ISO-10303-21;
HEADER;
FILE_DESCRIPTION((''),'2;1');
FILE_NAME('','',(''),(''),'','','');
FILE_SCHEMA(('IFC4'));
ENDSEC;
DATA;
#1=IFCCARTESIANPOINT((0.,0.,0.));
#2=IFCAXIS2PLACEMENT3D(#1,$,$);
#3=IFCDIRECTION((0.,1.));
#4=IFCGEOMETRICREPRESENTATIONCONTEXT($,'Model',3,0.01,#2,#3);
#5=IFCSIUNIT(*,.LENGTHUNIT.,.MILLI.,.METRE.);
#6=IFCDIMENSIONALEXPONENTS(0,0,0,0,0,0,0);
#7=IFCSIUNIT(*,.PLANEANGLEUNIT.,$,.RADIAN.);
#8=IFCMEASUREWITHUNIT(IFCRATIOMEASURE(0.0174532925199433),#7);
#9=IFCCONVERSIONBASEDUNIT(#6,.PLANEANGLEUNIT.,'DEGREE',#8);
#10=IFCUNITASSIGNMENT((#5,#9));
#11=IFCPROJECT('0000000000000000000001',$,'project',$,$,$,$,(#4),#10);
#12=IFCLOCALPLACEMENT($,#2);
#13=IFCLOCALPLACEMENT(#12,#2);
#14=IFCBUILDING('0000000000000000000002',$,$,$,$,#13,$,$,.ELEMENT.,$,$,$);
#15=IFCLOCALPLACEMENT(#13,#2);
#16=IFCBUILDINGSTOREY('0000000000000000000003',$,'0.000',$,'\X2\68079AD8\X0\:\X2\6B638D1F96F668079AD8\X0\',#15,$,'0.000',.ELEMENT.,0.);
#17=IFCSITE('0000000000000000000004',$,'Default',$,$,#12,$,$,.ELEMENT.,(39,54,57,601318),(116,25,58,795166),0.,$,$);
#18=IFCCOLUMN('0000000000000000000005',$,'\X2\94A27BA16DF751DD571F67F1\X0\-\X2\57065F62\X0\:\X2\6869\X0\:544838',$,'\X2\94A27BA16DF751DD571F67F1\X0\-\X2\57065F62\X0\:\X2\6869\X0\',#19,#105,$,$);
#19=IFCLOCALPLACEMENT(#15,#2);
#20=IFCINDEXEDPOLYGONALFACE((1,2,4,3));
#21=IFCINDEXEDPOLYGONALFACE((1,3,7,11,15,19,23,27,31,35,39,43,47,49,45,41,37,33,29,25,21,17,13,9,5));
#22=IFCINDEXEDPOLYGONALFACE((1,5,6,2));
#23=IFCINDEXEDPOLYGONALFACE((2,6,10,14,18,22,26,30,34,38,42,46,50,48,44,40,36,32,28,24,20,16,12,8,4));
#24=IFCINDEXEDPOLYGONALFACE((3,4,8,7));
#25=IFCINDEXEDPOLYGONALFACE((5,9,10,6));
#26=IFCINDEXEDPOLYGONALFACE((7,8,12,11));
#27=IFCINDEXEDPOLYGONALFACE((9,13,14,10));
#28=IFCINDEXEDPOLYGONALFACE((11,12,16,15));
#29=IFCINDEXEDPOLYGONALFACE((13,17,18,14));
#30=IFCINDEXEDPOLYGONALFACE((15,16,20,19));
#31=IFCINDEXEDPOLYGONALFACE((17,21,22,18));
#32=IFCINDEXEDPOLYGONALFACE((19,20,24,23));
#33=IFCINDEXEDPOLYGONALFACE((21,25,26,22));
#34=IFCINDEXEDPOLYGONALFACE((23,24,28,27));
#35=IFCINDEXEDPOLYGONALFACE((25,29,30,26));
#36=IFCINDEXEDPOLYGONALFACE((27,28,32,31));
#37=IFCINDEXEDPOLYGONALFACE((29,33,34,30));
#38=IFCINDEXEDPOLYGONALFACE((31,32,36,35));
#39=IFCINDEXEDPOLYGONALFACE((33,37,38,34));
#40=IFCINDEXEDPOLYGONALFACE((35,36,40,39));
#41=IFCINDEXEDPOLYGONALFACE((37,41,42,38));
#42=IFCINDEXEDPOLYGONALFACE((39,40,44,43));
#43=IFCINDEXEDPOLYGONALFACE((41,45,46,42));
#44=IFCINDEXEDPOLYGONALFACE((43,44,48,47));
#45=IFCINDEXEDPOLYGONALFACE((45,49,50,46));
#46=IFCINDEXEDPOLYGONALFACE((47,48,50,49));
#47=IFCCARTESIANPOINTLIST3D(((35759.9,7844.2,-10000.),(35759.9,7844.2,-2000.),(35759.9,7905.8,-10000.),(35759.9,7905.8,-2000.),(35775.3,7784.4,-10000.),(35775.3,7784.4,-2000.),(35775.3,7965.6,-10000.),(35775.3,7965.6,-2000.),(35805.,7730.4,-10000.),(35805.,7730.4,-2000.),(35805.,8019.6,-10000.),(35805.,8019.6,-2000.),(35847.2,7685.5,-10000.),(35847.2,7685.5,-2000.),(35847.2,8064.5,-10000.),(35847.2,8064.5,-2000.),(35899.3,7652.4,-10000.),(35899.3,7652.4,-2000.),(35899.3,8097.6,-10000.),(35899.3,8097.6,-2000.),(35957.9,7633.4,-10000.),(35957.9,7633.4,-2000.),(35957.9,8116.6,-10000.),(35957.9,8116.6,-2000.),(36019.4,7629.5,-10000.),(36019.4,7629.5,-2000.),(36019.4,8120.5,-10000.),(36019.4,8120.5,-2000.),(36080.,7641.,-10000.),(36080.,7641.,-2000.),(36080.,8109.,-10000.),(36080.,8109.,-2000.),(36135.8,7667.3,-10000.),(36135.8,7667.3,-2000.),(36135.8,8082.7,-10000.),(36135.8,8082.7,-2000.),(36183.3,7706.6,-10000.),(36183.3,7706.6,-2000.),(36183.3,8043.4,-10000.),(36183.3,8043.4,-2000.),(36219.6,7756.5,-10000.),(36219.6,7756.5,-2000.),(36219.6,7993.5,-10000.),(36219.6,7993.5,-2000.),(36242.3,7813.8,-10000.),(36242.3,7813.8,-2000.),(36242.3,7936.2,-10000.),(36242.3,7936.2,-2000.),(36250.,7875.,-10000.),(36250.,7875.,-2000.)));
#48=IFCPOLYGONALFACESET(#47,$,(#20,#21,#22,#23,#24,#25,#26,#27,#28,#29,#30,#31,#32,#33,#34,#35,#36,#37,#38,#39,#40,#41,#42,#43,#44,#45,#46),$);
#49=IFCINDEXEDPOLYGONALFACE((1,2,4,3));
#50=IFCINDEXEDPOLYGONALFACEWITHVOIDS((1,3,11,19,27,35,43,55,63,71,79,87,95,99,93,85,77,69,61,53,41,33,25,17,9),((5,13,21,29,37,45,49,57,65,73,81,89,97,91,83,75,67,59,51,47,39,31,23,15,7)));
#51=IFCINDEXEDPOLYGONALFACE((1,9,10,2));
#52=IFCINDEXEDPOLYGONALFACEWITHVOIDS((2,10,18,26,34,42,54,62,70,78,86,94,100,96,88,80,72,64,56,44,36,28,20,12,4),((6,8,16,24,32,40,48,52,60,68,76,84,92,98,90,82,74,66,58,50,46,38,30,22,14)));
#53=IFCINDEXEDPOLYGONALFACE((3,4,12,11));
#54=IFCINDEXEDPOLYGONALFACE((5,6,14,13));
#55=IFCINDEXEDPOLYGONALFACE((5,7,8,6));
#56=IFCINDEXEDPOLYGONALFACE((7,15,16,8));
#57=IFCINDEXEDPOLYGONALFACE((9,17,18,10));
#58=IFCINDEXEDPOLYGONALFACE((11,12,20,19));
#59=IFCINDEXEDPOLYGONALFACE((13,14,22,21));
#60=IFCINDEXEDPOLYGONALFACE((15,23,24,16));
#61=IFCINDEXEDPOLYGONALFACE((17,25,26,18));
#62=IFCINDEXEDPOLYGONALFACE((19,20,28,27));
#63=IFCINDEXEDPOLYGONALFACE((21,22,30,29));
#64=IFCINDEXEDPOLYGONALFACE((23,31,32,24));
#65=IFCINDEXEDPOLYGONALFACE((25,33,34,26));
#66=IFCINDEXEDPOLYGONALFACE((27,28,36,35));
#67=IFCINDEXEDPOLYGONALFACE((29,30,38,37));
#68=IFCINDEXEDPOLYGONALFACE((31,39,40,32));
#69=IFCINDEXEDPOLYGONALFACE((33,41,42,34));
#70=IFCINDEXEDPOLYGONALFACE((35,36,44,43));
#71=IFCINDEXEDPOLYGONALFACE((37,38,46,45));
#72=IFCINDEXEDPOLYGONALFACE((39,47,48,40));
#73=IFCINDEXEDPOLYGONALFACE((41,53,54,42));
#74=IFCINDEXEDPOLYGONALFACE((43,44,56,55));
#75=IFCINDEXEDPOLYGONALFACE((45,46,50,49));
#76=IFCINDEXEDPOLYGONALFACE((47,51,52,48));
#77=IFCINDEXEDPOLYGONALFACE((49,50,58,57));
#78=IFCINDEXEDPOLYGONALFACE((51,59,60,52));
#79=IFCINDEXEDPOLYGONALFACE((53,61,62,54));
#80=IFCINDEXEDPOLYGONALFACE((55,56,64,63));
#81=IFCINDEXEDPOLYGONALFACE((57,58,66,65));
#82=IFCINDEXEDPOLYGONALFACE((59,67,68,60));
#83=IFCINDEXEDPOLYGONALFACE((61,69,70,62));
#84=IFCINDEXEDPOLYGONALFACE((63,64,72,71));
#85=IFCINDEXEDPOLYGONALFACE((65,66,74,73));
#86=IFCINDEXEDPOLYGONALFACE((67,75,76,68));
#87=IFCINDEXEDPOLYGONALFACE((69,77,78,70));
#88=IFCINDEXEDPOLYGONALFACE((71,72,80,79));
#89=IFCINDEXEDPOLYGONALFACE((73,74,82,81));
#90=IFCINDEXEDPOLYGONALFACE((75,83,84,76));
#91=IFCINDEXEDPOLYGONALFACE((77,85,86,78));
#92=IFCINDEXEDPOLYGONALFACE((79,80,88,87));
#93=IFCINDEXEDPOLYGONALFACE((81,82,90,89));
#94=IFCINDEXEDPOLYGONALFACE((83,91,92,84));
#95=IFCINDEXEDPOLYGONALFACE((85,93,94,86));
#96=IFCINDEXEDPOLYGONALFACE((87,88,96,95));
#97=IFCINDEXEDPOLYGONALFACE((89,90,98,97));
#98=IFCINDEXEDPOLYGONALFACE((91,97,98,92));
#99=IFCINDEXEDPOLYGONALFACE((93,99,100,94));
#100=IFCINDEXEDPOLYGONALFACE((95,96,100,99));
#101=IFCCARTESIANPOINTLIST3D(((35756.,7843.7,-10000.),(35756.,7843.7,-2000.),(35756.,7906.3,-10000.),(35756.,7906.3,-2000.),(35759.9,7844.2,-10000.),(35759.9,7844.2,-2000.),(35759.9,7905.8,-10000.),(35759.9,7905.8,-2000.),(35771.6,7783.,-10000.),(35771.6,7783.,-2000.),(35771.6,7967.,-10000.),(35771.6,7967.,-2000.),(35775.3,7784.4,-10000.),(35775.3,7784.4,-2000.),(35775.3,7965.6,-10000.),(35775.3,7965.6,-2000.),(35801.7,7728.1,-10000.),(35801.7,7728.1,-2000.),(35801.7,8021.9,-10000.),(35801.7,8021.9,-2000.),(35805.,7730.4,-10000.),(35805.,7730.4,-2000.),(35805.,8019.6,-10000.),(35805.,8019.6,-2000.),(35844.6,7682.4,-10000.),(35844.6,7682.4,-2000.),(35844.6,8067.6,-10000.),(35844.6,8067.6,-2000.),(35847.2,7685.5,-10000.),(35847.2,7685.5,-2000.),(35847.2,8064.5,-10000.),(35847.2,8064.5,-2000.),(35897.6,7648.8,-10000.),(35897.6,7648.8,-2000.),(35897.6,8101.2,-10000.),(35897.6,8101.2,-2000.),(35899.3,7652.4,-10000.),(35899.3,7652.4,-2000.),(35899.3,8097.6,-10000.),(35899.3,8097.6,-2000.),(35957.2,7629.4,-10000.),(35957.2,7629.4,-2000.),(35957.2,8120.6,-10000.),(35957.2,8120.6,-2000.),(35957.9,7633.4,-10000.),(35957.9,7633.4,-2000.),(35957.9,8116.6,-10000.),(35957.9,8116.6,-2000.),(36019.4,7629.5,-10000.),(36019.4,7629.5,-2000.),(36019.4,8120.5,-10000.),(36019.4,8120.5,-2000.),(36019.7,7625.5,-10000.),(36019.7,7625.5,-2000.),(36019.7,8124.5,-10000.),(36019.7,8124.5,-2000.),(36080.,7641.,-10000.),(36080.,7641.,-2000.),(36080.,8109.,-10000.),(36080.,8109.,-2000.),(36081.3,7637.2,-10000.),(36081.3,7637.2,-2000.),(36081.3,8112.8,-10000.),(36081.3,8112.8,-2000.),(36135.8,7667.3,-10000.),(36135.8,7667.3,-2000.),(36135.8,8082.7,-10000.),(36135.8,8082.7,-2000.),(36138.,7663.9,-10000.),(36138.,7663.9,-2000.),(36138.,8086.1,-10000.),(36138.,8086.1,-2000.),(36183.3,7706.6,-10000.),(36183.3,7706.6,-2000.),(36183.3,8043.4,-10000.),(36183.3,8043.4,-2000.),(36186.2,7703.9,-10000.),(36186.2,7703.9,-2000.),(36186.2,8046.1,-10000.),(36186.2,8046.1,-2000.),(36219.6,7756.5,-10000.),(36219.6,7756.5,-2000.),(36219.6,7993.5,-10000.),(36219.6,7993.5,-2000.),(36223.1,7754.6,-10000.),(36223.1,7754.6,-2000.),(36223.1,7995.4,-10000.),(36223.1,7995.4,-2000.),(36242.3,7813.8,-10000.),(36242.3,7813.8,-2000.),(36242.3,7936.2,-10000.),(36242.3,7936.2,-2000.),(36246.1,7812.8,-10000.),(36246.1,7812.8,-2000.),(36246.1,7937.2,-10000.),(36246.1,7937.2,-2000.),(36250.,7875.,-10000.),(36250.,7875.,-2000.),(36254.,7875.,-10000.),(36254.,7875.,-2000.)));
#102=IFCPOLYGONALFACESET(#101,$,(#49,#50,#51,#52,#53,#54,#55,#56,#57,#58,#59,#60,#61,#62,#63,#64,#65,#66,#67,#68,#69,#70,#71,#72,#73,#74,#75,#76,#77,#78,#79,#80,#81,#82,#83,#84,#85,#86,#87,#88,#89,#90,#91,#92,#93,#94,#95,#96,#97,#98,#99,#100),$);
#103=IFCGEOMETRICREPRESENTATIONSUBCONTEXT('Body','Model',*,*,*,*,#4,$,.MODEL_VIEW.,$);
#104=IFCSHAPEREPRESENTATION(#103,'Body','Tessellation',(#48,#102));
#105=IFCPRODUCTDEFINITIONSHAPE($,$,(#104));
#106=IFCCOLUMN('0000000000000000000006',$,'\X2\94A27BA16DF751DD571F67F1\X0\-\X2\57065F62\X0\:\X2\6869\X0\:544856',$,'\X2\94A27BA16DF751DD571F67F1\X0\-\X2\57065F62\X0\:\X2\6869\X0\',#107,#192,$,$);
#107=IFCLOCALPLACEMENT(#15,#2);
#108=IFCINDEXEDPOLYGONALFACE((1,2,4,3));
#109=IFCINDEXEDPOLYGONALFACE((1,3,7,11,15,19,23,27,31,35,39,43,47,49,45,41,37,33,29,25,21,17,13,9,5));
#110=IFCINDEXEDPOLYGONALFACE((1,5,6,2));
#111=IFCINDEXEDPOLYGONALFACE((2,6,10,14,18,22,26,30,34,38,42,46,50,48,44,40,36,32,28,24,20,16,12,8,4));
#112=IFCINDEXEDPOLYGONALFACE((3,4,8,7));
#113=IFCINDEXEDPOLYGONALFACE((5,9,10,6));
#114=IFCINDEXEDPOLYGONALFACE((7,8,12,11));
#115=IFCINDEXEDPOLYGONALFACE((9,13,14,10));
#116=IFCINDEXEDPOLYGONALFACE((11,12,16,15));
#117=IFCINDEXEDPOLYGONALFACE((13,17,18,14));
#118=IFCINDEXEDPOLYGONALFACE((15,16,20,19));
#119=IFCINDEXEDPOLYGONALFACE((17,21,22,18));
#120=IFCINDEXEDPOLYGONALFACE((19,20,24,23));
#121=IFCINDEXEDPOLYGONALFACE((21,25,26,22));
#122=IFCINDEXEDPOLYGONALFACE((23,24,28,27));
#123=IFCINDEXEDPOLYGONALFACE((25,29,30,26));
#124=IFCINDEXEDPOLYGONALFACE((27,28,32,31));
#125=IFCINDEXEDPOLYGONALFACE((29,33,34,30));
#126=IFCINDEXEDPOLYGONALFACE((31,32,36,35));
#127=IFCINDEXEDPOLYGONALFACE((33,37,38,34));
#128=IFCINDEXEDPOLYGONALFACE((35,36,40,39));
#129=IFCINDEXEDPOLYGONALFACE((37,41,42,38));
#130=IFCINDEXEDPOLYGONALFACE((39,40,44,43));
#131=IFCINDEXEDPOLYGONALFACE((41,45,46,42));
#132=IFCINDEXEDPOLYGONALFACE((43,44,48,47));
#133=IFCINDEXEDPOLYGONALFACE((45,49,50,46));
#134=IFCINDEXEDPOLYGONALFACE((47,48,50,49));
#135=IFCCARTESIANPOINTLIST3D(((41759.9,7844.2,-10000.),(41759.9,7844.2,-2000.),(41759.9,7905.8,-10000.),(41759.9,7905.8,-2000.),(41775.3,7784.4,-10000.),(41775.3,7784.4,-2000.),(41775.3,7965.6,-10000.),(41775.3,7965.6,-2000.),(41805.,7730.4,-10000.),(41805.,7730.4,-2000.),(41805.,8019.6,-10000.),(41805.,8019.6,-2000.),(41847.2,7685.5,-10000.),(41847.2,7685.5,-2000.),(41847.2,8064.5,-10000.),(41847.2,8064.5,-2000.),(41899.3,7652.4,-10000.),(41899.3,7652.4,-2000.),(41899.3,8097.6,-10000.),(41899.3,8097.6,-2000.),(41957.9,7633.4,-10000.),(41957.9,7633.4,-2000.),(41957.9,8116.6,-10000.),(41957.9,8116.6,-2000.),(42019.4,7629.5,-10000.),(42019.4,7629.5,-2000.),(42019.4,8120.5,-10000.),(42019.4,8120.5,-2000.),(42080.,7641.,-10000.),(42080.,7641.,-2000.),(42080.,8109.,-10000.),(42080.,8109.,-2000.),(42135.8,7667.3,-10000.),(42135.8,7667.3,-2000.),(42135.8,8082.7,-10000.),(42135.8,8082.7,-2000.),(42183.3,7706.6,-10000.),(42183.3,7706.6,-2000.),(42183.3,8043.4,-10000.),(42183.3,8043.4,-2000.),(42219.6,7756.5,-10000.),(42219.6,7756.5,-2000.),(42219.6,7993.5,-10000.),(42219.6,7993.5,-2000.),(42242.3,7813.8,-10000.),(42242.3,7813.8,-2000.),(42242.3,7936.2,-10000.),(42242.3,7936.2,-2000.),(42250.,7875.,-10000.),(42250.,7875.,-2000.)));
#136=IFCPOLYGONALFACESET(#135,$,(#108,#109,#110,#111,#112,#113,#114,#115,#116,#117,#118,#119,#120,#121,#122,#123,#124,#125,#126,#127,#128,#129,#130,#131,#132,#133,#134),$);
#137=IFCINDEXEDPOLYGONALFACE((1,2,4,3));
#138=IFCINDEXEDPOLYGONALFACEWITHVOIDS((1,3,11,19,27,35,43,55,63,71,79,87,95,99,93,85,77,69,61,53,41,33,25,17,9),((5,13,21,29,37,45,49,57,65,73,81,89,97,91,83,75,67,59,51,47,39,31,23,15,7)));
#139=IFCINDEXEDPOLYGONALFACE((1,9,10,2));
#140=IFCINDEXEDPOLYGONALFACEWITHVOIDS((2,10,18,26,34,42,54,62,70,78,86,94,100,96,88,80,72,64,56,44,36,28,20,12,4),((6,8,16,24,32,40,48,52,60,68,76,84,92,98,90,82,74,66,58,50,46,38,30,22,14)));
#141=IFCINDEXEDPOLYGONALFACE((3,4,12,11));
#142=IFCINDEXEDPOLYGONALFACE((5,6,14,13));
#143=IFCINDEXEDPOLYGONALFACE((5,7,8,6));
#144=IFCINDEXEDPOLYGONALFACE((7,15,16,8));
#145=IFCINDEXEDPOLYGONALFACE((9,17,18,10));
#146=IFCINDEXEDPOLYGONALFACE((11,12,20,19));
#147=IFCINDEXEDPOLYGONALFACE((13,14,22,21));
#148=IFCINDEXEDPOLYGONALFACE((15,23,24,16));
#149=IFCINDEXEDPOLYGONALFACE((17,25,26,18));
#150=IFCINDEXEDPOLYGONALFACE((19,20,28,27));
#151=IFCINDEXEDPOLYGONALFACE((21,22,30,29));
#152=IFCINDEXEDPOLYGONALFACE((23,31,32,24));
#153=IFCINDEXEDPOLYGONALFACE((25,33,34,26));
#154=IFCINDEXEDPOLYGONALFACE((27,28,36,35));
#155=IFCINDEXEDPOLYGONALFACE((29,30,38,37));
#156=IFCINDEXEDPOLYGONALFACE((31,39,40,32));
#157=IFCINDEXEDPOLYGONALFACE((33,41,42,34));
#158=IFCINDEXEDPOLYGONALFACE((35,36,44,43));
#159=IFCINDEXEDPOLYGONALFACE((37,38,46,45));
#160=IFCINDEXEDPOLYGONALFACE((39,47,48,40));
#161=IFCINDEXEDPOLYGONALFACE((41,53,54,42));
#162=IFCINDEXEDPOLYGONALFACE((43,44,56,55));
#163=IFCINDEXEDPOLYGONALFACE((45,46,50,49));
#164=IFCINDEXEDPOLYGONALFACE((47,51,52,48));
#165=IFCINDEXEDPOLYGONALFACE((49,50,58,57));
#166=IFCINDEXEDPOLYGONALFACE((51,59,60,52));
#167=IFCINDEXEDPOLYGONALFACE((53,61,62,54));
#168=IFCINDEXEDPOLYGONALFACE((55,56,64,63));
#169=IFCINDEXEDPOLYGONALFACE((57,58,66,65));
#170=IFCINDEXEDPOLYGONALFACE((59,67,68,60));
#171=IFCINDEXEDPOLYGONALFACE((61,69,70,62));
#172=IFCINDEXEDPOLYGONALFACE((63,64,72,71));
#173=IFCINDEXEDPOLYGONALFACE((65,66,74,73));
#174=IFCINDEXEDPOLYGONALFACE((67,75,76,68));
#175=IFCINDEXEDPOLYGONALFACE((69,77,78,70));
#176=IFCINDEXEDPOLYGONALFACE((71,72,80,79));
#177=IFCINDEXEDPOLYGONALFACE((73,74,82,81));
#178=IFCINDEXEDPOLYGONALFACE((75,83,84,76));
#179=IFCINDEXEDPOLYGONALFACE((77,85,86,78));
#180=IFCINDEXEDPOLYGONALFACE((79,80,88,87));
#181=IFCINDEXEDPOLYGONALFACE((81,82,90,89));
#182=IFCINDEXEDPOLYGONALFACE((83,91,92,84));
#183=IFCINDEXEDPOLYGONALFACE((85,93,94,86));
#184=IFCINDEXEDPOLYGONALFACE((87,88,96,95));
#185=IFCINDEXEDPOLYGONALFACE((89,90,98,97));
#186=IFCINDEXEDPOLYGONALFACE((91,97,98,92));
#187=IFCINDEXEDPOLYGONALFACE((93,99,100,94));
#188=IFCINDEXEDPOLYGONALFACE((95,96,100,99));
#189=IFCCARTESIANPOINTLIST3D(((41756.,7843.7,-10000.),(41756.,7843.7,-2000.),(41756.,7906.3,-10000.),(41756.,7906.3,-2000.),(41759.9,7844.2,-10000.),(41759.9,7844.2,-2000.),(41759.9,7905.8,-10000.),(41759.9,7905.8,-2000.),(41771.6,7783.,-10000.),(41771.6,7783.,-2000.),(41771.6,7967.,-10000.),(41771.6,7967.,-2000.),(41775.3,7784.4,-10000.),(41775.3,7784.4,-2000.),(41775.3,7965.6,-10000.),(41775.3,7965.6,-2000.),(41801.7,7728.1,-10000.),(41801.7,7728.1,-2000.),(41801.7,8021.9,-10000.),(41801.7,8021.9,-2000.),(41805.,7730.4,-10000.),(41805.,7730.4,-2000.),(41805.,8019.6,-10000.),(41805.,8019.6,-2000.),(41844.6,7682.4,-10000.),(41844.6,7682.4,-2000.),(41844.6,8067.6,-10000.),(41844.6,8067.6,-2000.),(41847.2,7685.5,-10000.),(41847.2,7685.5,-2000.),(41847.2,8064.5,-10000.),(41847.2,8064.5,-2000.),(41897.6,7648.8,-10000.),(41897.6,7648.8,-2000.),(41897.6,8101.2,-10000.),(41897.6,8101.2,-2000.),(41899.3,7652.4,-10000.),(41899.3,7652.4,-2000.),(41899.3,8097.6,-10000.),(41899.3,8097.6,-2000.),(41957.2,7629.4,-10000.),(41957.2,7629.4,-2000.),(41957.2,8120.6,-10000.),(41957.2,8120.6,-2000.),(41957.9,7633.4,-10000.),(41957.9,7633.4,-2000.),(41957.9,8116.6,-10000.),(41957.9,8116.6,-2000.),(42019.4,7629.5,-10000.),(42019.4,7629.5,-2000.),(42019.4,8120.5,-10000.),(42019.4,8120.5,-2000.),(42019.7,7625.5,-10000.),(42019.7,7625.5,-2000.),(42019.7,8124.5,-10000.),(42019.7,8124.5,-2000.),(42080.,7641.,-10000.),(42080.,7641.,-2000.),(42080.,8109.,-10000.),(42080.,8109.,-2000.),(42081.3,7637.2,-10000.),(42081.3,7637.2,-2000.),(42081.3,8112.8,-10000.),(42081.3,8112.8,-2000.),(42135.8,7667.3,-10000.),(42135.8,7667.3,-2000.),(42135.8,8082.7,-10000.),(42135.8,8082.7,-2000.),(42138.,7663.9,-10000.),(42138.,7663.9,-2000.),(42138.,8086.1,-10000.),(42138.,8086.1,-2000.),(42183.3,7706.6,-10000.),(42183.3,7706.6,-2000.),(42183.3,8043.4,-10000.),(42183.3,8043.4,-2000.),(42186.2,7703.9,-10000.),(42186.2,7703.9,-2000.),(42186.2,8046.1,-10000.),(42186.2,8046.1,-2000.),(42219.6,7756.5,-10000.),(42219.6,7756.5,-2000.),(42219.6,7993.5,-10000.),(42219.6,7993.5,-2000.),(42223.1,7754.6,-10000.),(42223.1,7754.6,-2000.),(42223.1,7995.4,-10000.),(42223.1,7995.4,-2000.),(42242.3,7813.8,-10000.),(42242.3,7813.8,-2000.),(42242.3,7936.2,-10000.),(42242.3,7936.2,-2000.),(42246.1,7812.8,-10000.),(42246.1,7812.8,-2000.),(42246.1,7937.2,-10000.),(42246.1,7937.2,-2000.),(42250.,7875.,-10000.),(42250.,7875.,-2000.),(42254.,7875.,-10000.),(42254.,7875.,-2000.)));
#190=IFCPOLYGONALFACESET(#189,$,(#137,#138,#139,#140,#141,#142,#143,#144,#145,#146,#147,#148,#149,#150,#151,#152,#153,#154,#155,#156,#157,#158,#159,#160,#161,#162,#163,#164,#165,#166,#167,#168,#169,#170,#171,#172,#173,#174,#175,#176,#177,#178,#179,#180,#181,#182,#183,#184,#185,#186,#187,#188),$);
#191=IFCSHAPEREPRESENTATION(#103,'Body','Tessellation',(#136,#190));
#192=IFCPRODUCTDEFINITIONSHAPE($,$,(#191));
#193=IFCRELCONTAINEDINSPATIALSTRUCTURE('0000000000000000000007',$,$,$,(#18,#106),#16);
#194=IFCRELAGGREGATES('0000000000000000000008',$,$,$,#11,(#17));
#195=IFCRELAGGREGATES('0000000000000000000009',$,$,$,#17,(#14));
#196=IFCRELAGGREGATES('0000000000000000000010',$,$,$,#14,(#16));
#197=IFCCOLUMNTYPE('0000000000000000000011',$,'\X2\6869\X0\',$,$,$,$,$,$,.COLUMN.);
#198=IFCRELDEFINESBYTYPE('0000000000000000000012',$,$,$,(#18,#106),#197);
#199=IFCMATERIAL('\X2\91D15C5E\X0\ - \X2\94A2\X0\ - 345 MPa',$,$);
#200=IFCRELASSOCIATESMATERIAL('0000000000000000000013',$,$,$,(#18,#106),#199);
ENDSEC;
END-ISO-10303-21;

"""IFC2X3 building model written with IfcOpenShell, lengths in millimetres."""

from ifc_helpers import new_model, entity, si_unit, converted_unit, direction, frame, frame_2d, origin, place, context, subcontext, project, spatial, circle, hollow_circle, extrude, source, transform, mapped, material, type_object, type_shapes, element, save


model = new_model("IFC2X3")

# Units and contexts
model_context = context("Model", 3, precision=0.01, world=origin(), true_north=direction((0.0, 1.0)))
body_context = subcontext(model_context, "Body", "Model", "MODEL_VIEW")
ifc_project = project(units=[si_unit("LENGTHUNIT", "METRE", prefix="MILLI"), converted_unit("PLANEANGLEUNIT", "DEGREE", entity("IfcRatioMeasure", 0.0174532925199433), si_unit("PLANEANGLEUNIT", "RADIAN"), dimensions=[0, 0, 0, 0, 0, 0, 0])], contexts=[model_context])

# Site, building, storey
site_placement = place(None, origin())
site = spatial("IfcSite", under=ifc_project, at=site_placement, Name="Default", CompositionType="ELEMENT", RefLatitude=(39, 54, 57, 601318), RefLongitude=(116, 25, 58, 795166), RefElevation=0.0)
building_placement = place(site_placement, origin())
building = spatial("IfcBuilding", under=site, at=building_placement, CompositionType="ELEMENT")
storey_placement = place(building_placement, origin())
storey = spatial("IfcBuildingStorey", under=building, at=storey_placement, Name="0.000", ObjectType="标高:正负零标高", LongName="0.000", CompositionType="ELEMENT", Elevation=0.0)

# Columns
ifc_material_1 = material(Name="金属 - 钢 - 345 MPa")
column_type = type_object("IfcColumnType", Name="桩", PredefinedType="COLUMN")
shared_shape = source(origin(), body_context, "Body", "SweptSolid", [
    extrude(circle(Radius=246.0, at=frame_2d((0.0, 0.0), x_axis=(1.0, 0.0))), frame((0.0, 0.0, -10000.0)), (0.0, 0.0, 1.0), 8000.0),
    extrude(hollow_circle(Radius=250.0, WallThickness=4.0, at=frame_2d((0.0, 0.0), x_axis=(1.0, 0.0))), frame((0.0, 0.0, -10000.0)), (0.0, 0.0, 1.0), 8000.0),
])
type_shapes(column_type, [shared_shape])
for number, where, name in (
    (1, (36004.0, 7875.0, 0.0), "钢管混凝土柱-圆形:桩:544838"),
    (2, (42004.0, 7875.0, 0.0), "钢管混凝土柱-圆形:桩:544856"),
):
    element("IfcColumn", number, at=place(storey_placement, frame(where)), inside=storey, type_object=column_type, material=ifc_material_1, Name=name, ObjectType="钢管混凝土柱-圆形:桩", context=body_context, shape_type="MappedRepresentation", body=[
        mapped(shared_shape, transform((0.0, 0.0, 0.0), scale=1.0)),
    ])

save(model, "model.ifc")
